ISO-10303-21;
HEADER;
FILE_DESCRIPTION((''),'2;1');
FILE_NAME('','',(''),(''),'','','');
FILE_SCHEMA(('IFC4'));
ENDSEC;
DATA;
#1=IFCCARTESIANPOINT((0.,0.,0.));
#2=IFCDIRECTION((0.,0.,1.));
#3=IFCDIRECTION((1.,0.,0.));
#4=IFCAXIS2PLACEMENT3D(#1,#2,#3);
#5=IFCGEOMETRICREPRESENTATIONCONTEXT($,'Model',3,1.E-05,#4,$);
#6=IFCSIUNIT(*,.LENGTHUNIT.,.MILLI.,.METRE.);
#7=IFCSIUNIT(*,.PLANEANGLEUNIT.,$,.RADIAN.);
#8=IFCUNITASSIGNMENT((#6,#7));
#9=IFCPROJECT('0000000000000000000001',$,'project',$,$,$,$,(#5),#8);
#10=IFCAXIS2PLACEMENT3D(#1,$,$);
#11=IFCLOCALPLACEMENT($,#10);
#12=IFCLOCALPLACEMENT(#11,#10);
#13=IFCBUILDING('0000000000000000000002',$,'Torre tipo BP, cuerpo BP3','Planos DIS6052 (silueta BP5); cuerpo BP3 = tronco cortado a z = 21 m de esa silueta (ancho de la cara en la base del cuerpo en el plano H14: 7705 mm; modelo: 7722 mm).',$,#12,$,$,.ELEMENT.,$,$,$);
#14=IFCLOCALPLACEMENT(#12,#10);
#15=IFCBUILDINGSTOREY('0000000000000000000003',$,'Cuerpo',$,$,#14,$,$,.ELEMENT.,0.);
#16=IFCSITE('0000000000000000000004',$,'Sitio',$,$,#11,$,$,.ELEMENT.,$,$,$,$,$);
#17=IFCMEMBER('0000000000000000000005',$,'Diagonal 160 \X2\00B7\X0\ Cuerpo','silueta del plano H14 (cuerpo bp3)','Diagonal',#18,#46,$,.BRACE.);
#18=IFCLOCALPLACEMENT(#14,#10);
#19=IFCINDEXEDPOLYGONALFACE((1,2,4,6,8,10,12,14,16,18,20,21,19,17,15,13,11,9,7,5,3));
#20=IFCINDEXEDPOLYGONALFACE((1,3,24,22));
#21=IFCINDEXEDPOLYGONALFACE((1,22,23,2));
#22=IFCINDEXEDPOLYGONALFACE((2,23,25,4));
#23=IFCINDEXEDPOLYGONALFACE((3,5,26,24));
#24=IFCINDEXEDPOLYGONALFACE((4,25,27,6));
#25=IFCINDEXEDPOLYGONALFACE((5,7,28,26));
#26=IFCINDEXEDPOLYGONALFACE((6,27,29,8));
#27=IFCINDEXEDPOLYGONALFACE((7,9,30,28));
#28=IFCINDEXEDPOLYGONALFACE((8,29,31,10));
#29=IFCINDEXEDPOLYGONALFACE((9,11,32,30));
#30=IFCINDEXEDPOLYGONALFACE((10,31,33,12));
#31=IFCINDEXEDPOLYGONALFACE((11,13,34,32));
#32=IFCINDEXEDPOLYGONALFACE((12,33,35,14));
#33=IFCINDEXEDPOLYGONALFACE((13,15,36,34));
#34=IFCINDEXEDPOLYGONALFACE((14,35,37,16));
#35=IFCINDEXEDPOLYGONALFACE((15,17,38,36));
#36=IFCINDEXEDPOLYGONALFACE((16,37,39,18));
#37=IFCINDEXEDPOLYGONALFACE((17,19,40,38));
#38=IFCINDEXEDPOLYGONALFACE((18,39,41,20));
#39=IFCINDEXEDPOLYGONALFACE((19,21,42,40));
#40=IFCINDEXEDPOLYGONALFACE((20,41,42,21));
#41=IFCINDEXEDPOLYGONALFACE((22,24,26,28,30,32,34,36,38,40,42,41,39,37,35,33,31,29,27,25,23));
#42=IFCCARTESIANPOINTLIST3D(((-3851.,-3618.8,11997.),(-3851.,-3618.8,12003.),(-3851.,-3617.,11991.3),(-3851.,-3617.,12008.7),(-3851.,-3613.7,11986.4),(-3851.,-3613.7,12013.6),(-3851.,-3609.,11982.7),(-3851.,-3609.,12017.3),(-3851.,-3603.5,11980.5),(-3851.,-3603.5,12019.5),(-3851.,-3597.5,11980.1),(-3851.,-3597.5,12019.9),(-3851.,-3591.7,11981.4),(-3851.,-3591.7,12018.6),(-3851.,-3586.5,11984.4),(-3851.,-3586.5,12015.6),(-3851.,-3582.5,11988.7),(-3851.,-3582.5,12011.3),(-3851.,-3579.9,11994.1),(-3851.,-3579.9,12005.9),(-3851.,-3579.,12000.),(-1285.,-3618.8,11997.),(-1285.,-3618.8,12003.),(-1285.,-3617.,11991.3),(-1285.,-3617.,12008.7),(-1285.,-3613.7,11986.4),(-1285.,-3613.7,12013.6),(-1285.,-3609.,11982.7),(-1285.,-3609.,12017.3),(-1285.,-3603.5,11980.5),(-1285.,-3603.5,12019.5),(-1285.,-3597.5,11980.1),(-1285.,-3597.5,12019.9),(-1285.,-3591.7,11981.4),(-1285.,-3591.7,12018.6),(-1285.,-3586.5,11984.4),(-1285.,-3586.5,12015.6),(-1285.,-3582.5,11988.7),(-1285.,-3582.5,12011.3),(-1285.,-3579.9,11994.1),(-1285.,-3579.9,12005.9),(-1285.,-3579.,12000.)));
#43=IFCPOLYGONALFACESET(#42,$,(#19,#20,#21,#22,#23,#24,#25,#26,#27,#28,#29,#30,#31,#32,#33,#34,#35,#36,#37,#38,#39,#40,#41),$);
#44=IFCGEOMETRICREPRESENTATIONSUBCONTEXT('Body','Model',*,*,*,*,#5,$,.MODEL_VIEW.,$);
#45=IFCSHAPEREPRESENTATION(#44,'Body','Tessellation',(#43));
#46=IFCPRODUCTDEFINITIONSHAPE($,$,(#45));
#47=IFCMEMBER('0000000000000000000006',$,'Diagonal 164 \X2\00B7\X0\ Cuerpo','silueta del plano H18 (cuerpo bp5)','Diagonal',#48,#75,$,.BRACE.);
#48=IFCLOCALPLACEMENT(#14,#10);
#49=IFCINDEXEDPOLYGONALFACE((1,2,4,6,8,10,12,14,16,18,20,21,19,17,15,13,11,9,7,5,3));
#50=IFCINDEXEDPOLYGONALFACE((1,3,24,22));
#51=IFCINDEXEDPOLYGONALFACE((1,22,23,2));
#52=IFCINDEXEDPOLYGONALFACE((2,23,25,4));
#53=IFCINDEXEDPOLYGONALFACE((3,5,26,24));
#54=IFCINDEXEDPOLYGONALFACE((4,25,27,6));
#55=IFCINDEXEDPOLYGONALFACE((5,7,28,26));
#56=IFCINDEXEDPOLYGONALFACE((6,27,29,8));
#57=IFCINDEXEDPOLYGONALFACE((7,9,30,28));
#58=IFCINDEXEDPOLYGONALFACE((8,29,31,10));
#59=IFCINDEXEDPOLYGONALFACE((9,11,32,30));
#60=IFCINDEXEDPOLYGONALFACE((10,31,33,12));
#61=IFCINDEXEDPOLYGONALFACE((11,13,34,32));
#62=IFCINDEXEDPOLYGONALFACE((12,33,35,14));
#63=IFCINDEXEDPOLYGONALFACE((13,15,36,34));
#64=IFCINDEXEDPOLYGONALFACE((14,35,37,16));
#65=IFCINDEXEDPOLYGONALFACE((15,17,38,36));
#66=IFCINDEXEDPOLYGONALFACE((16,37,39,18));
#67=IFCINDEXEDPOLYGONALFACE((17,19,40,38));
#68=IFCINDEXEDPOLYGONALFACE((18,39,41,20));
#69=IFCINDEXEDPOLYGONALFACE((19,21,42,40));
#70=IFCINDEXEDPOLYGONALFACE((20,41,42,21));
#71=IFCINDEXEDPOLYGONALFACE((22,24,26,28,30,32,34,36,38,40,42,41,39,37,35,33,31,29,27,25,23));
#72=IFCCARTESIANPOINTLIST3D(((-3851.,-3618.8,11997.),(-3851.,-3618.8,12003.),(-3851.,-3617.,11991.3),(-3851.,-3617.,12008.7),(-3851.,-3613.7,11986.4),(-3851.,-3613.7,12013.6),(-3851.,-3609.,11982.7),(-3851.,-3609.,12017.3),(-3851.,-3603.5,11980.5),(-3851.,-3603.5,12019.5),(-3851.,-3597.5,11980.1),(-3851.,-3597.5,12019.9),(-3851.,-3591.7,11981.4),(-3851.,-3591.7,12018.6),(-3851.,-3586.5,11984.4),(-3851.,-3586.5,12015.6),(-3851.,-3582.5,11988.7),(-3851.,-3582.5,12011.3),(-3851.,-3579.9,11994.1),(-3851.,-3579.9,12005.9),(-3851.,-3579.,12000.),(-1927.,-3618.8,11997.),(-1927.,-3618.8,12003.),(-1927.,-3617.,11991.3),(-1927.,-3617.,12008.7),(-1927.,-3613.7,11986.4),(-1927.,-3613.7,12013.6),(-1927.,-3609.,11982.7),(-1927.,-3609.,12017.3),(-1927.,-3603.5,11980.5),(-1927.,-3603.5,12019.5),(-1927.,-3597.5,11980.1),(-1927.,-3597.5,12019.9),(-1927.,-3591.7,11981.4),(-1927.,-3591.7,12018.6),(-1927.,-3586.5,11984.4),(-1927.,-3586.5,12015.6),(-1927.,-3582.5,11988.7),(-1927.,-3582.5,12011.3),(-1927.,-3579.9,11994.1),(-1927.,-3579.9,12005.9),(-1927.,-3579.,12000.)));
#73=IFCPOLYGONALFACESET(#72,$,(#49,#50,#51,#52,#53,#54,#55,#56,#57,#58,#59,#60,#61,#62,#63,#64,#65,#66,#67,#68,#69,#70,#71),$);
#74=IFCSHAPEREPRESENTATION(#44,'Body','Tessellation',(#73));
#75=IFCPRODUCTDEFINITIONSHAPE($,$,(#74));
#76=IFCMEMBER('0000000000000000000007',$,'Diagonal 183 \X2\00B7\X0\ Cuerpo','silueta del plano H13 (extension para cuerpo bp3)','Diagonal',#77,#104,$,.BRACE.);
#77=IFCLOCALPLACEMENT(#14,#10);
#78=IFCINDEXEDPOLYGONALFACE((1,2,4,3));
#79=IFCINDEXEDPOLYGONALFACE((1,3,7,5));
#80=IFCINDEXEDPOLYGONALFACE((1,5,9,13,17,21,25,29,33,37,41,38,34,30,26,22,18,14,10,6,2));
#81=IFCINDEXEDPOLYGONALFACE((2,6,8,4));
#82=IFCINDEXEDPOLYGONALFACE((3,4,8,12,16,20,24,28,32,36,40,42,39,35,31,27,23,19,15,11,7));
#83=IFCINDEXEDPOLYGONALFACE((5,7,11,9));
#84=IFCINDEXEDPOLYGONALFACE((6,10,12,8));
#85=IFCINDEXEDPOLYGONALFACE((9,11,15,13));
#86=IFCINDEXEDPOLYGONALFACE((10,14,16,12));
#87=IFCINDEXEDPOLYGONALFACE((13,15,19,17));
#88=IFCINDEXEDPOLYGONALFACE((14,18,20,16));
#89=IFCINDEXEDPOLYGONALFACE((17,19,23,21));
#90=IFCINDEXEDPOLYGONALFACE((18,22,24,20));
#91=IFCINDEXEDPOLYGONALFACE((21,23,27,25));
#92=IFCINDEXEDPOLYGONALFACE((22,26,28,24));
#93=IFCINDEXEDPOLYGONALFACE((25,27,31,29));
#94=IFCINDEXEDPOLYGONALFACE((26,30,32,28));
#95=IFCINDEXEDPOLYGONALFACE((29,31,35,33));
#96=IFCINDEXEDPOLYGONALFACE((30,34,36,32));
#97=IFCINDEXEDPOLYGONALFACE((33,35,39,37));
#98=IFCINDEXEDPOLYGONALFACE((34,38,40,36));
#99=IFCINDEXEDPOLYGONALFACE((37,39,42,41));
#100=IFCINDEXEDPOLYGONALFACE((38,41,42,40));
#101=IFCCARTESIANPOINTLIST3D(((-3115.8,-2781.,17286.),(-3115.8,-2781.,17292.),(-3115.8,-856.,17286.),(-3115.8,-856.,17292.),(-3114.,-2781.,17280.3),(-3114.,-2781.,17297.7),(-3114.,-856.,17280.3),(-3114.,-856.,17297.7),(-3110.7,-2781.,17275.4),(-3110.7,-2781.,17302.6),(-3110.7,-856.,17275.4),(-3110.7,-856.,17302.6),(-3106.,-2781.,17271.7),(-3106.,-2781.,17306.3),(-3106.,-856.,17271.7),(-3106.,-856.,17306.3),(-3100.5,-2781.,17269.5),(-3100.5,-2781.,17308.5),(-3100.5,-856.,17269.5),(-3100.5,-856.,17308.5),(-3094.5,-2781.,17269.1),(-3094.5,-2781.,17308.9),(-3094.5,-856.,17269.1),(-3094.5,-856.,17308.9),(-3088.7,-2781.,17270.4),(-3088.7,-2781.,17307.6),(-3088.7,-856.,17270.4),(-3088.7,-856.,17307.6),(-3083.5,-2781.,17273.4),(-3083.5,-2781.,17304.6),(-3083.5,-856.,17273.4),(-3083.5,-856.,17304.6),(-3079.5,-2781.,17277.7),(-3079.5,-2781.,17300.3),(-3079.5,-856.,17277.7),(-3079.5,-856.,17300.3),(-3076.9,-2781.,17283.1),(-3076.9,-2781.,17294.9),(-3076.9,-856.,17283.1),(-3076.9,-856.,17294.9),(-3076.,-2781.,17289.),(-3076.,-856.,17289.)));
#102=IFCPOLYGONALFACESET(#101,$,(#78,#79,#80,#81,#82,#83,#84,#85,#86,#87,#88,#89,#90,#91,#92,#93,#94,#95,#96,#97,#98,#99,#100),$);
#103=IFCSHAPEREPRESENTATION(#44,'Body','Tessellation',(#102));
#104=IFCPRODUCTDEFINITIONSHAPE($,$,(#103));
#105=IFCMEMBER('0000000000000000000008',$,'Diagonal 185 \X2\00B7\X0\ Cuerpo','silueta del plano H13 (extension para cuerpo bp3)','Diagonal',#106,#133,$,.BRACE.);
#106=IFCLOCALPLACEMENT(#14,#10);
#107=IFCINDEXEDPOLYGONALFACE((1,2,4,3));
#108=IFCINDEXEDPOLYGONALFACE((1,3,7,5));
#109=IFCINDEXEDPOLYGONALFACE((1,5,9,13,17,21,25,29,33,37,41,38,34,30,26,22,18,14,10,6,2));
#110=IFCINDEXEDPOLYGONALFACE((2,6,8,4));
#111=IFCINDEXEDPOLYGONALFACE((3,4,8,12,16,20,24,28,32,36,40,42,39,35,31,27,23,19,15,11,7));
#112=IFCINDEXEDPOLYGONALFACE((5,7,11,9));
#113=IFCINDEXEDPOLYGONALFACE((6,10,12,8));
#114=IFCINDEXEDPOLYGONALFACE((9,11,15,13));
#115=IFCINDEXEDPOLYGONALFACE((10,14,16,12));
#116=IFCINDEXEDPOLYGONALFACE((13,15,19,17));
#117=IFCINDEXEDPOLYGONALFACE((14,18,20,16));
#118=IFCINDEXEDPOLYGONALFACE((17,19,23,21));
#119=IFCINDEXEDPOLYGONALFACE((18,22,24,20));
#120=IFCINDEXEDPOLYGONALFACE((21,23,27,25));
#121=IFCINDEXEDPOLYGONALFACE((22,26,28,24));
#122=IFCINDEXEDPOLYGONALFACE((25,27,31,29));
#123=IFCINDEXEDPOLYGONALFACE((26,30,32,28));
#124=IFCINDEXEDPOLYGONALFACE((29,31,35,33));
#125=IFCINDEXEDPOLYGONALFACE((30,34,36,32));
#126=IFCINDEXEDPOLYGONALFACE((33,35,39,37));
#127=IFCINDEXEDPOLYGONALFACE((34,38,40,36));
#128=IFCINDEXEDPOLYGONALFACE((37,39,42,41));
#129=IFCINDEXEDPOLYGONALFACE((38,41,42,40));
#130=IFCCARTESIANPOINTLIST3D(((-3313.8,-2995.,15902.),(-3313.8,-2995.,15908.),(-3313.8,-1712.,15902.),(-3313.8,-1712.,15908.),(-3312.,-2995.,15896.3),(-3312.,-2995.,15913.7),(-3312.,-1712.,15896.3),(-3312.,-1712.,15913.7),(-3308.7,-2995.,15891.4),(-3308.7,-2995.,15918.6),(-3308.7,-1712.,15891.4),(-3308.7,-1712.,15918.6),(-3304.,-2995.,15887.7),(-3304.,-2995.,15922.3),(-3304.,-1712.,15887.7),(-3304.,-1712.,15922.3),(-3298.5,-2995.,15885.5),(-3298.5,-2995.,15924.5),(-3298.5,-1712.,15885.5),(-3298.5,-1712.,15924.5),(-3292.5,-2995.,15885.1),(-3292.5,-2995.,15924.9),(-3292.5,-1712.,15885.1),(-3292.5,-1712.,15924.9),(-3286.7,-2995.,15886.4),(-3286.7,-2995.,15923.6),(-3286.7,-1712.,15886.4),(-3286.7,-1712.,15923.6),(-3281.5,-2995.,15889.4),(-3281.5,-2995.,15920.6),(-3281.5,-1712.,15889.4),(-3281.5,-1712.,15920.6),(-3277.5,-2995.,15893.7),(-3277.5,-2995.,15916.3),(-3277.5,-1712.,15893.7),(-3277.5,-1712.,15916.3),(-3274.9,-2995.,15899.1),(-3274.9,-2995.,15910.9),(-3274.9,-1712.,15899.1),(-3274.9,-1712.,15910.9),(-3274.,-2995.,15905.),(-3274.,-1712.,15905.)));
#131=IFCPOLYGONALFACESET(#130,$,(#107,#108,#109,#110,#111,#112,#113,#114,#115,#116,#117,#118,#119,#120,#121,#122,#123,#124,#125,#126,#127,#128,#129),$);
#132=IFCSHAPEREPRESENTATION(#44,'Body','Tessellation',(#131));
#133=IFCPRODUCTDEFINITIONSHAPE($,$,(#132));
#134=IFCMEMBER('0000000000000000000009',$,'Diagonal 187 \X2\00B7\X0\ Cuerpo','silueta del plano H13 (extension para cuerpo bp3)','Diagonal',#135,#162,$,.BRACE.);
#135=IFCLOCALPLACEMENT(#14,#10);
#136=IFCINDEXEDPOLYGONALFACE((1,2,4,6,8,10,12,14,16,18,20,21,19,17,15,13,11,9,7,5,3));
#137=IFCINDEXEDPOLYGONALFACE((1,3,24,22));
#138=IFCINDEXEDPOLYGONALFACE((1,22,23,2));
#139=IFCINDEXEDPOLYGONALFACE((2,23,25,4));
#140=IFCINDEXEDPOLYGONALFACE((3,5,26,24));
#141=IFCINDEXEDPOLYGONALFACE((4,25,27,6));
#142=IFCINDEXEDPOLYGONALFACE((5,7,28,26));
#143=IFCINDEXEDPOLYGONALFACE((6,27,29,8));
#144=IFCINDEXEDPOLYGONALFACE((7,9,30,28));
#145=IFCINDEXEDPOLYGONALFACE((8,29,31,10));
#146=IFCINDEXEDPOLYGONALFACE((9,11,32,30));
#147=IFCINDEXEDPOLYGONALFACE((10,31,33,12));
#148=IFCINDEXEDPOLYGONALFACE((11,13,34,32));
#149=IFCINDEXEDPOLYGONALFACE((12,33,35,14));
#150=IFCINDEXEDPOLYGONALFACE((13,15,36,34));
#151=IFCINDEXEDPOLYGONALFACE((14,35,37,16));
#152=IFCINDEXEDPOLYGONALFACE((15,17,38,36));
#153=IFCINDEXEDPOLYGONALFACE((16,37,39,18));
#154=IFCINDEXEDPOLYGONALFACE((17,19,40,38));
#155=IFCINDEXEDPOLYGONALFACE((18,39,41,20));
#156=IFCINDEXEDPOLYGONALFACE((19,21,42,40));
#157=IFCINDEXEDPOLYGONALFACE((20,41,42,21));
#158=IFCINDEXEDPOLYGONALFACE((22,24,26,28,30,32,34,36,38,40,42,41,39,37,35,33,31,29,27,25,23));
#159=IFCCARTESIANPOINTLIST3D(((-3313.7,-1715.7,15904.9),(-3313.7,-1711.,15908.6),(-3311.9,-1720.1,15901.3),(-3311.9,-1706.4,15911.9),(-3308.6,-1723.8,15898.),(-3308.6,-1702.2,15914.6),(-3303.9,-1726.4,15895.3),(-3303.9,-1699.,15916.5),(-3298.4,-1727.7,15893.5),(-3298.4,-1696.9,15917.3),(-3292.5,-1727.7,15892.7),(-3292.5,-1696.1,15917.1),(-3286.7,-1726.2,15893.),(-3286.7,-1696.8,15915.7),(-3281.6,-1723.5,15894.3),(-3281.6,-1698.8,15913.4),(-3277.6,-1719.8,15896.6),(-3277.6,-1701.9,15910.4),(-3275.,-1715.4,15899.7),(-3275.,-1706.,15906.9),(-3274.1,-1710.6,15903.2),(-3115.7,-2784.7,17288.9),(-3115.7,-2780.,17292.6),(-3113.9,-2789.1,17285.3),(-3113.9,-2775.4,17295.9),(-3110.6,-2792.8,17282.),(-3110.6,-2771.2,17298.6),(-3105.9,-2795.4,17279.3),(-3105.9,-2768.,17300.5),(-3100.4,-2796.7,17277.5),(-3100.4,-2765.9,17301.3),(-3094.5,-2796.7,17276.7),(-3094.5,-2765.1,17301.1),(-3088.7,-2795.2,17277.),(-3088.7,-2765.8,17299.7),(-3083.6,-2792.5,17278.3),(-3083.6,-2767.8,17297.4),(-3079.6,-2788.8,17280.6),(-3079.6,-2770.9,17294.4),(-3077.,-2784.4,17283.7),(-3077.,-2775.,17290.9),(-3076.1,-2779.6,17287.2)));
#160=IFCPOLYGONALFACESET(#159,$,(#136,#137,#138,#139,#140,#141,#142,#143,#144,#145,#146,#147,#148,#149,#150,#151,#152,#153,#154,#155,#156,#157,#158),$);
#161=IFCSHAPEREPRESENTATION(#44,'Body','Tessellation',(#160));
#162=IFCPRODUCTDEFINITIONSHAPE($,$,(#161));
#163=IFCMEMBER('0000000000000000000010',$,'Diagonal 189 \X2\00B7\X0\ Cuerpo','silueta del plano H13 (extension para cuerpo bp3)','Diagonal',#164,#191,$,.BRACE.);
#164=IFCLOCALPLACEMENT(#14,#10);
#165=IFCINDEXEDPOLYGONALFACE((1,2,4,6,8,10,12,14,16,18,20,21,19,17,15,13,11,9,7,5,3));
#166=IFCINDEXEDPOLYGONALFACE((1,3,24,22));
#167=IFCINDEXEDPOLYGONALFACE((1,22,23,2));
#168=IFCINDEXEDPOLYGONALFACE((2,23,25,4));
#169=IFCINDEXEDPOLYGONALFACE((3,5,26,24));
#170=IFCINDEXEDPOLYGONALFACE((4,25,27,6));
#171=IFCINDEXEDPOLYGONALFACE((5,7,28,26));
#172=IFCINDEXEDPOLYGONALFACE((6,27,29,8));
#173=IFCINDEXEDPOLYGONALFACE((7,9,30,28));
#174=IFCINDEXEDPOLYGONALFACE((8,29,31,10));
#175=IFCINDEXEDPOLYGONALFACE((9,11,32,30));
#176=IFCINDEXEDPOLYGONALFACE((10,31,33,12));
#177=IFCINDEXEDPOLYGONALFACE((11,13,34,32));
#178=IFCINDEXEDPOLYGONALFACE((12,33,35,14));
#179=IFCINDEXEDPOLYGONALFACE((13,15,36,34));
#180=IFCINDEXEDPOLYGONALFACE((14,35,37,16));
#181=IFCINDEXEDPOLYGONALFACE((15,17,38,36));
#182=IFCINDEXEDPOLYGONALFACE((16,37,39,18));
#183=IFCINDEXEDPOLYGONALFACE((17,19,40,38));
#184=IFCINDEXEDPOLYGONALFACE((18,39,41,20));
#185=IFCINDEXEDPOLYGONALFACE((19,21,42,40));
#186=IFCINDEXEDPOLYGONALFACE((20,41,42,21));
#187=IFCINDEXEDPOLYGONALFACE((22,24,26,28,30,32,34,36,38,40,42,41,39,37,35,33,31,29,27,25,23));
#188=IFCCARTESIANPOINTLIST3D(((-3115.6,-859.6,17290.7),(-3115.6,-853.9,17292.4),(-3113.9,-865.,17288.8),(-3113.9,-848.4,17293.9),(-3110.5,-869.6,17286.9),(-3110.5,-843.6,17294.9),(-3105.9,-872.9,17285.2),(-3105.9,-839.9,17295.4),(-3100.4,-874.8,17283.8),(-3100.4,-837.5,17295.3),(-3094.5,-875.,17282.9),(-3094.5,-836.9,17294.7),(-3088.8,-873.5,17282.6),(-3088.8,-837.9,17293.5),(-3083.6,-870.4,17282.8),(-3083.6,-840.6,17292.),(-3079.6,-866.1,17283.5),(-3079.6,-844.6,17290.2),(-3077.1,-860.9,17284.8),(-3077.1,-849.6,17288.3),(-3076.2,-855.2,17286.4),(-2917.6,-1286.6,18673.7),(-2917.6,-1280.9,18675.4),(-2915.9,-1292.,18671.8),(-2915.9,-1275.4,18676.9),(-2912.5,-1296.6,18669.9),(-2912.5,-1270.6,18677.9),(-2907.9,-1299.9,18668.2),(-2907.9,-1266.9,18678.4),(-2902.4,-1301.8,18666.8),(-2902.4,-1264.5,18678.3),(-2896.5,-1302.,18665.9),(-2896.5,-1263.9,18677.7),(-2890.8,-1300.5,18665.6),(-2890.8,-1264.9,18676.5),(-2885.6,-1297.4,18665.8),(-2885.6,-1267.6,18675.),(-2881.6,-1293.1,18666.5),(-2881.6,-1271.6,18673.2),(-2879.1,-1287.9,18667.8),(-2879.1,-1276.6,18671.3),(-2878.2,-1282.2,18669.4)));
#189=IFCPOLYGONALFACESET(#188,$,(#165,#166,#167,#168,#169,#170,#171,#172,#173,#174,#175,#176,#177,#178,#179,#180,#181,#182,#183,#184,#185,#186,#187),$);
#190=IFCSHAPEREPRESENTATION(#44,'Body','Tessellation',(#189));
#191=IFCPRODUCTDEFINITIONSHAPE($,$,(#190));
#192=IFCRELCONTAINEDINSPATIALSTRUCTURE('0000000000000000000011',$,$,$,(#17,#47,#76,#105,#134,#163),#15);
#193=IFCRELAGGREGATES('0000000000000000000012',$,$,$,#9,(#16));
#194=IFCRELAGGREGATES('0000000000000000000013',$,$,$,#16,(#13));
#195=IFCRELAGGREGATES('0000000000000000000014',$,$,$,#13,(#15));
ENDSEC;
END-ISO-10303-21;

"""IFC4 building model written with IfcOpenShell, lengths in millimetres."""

from ifc_helpers import new_model, si_unit, frame, origin, origin_with_axes, place, context, subcontext, project, spatial, circle, extrude, element, save


model = new_model("IFC4")

# Units and contexts
model_context = context("Model", 3, precision=1e-05, world=origin_with_axes())
body_context = subcontext(model_context, "Body", "Model", "MODEL_VIEW")
ifc_project = project(units=[si_unit("LENGTHUNIT", "METRE", prefix="MILLI"), si_unit("PLANEANGLEUNIT", "RADIAN")], contexts=[model_context])

# Site, building, storey
site_placement = place(None, origin())
site = spatial("IfcSite", under=ifc_project, at=site_placement, Name="Sitio", CompositionType="ELEMENT")
building_placement = place(site_placement, origin())
building = spatial("IfcBuilding", under=site, at=building_placement, Name="Torre tipo BP, cuerpo BP3", Description="Planos DIS6052 (silueta BP5); cuerpo BP3 = tronco cortado a z = 21 m de esa silueta (ancho de la cara en la base del cuerpo en el plano H14: 7705 mm; modelo: 7722 mm).", CompositionType="ELEMENT")
storey_placement = place(building_placement, origin())
storey = spatial("IfcBuildingStorey", under=building, at=storey_placement, Name="Cuerpo", CompositionType="ELEMENT", Elevation=0.0)

# Members
member_1_placement = place(storey_placement, frame((-3851.0, -3599.0, 12000.0), z_axis=(1.0, 0.0, 0.0), x_axis=(0.0, 1.0, 0.0)))
element("IfcMember", 1, at=member_1_placement, inside=storey, Name="Diagonal 160 · Cuerpo", Description="silueta del plano H14 (cuerpo bp3)", ObjectType="Diagonal", PredefinedType="BRACE", context=body_context, shape_type="SweptSolid", body=[
    extrude(circle(Radius=20.0), None, (0.0, 0.0, 1.0), 2566.0),
])
member_2_placement = place(storey_placement, frame((-3851.0, -3599.0, 12000.0), z_axis=(1.0, 0.0, 0.0), x_axis=(0.0, 1.0, 0.0)))
element("IfcMember", 2, at=member_2_placement, inside=storey, Name="Diagonal 164 · Cuerpo", Description="silueta del plano H18 (cuerpo bp5)", ObjectType="Diagonal", PredefinedType="BRACE", context=body_context, shape_type="SweptSolid", body=[
    extrude(circle(Radius=20.0), None, (0.0, 0.0, 1.0), 1924.0),
])
member_3_placement = place(storey_placement, frame((-3096.0, -856.0, 17289.0), z_axis=(0.0, -1.0, 0.0), x_axis=(1.0, 0.0, 0.0)))
element("IfcMember", 3, at=member_3_placement, inside=storey, Name="Diagonal 183 · Cuerpo", Description="silueta del plano H13 (extension para cuerpo bp3)", ObjectType="Diagonal", PredefinedType="BRACE", context=body_context, shape_type="SweptSolid", body=[
    extrude(circle(Radius=20.0), None, (0.0, 0.0, 1.0), 1925.0),
])
member_4_placement = place(storey_placement, frame((-3294.0, -1712.0, 15905.0), z_axis=(0.0, -1.0, 0.0), x_axis=(1.0, 0.0, 0.0)))
element("IfcMember", 4, at=member_4_placement, inside=storey, Name="Diagonal 185 · Cuerpo", Description="silueta del plano H13 (extension para cuerpo bp3)", ObjectType="Diagonal", PredefinedType="BRACE", context=body_context, shape_type="SweptSolid", body=[
    extrude(circle(Radius=20.0), None, (0.0, 0.0, 1.0), 1283.0),
])
member_5_placement = place(storey_placement, frame((-3294.0, -1712.0, 15905.0), z_axis=(0.112503, -0.607404, 0.786386), x_axis=(0.993651, 0.068772, -0.089036)))
element("IfcMember", 5, at=member_5_placement, inside=storey, Name="Diagonal 187 · Cuerpo", Description="silueta del plano H13 (extension para cuerpo bp3)", ObjectType="Diagonal", PredefinedType="BRACE", context=body_context, shape_type="SweptSolid", body=[
    extrude(circle(Radius=20.0), None, (0.0, 0.0, 1.0), 1759.9),
])
member_6_placement = place(storey_placement, frame((-3096.0, -856.0, 17289.0), z_axis=(0.135533, -0.292286, 0.946678), x_axis=(0.990773, 0.039983, -0.129501)))
element("IfcMember", 6, at=member_6_placement, inside=storey, Name="Diagonal 189 · Cuerpo", Description="silueta del plano H13 (extension para cuerpo bp3)", ObjectType="Diagonal", PredefinedType="BRACE", context=body_context, shape_type="SweptSolid", body=[
    extrude(circle(Radius=20.0), None, (0.0, 0.0, 1.0), 1460.9),
])

save(model, "model.ifc")
